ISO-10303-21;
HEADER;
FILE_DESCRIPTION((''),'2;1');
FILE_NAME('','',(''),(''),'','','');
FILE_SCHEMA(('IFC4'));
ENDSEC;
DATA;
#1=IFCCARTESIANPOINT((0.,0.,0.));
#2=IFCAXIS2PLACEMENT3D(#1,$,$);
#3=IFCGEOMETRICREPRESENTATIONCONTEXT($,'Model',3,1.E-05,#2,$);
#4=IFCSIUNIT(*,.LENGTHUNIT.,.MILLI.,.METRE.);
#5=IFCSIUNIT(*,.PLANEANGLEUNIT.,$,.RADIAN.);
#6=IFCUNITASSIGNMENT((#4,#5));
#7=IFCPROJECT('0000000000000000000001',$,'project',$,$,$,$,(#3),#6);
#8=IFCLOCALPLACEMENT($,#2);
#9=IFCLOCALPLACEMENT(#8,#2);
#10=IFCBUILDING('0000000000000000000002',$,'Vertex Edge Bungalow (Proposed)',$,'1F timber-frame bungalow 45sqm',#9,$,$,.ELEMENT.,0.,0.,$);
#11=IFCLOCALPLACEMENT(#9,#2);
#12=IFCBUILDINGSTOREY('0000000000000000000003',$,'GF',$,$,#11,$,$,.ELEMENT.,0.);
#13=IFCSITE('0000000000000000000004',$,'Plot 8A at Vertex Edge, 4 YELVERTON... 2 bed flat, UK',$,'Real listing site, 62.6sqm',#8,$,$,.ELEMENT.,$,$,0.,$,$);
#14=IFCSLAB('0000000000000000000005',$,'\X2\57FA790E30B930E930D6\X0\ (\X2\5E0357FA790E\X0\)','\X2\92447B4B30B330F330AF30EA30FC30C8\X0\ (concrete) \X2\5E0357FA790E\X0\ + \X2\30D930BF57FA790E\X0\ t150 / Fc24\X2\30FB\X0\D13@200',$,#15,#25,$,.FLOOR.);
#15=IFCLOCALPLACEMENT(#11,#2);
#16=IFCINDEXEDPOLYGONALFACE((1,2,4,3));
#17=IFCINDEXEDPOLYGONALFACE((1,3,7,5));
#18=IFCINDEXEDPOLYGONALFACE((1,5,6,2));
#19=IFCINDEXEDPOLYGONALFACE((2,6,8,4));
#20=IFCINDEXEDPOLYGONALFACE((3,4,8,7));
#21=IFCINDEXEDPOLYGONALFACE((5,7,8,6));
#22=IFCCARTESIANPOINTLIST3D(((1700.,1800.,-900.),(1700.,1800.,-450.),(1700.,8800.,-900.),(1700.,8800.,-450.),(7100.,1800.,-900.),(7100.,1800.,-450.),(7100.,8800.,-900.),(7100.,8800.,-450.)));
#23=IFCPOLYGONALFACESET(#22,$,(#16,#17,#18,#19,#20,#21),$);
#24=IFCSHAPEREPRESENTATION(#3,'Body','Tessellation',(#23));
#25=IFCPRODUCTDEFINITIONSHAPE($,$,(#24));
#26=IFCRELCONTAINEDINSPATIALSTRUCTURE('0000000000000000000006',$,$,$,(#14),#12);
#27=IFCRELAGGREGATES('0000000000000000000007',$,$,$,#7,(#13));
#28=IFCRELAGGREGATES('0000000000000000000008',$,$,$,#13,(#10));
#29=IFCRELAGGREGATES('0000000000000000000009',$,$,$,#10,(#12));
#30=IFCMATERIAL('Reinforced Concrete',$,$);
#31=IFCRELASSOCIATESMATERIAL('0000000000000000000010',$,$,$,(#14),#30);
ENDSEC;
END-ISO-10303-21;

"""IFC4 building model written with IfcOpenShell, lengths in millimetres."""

from ifc_helpers import new_model, si_unit, frame, frame_2d, origin, place, context, project, spatial, rectangle, extrude, material, element, save


model = new_model("IFC4")

# Units and contexts
model_context = context("Model", 3, precision=1e-05, world=origin())
ifc_project = project(units=[si_unit("LENGTHUNIT", "METRE", prefix="MILLI"), si_unit("PLANEANGLEUNIT", "RADIAN")], contexts=[model_context])

# Site, building, storey
site_placement = place(None, origin())
site = spatial("IfcSite", under=ifc_project, at=site_placement, Name="Plot 8A at Vertex Edge, 4 YELVERTON... 2 bed flat, UK", ObjectType="Real listing site, 62.6sqm", CompositionType="ELEMENT", RefElevation=0.0)
building_placement = place(site_placement, origin())
building = spatial("IfcBuilding", under=site, at=building_placement, Name="Vertex Edge Bungalow (Proposed)", ObjectType="1F timber-frame bungalow 45sqm", CompositionType="ELEMENT", ElevationOfRefHeight=0.0, ElevationOfTerrain=0.0)
storey_placement = place(building_placement, origin())
storey = spatial("IfcBuildingStorey", under=building, at=storey_placement, Name="GF", CompositionType="ELEMENT", Elevation=0.0)

# Slab
ifc_material_1 = material(Name="Reinforced Concrete")
slab_1_placement = place(storey_placement, frame((850.0, 900.0, -450.0)))
element("IfcSlab", 1, at=slab_1_placement, inside=storey, material=ifc_material_1, Name="基礎スラブ (布基礎)", Description="鉄筋コンクリート (concrete) 布基礎 + ベタ基礎 t150 / Fc24・D13@200", PredefinedType="FLOOR", context=model_context, shape_type="SweptSolid", body=[
    extrude(rectangle(XDim=5400.0, YDim=7000.0, at=frame_2d((2700.0, 3500.0))), frame((850.0, 900.0, -450.0)), (0.0, 0.0, 1.0), 450.0),
])

save(model, "model.ifc")
